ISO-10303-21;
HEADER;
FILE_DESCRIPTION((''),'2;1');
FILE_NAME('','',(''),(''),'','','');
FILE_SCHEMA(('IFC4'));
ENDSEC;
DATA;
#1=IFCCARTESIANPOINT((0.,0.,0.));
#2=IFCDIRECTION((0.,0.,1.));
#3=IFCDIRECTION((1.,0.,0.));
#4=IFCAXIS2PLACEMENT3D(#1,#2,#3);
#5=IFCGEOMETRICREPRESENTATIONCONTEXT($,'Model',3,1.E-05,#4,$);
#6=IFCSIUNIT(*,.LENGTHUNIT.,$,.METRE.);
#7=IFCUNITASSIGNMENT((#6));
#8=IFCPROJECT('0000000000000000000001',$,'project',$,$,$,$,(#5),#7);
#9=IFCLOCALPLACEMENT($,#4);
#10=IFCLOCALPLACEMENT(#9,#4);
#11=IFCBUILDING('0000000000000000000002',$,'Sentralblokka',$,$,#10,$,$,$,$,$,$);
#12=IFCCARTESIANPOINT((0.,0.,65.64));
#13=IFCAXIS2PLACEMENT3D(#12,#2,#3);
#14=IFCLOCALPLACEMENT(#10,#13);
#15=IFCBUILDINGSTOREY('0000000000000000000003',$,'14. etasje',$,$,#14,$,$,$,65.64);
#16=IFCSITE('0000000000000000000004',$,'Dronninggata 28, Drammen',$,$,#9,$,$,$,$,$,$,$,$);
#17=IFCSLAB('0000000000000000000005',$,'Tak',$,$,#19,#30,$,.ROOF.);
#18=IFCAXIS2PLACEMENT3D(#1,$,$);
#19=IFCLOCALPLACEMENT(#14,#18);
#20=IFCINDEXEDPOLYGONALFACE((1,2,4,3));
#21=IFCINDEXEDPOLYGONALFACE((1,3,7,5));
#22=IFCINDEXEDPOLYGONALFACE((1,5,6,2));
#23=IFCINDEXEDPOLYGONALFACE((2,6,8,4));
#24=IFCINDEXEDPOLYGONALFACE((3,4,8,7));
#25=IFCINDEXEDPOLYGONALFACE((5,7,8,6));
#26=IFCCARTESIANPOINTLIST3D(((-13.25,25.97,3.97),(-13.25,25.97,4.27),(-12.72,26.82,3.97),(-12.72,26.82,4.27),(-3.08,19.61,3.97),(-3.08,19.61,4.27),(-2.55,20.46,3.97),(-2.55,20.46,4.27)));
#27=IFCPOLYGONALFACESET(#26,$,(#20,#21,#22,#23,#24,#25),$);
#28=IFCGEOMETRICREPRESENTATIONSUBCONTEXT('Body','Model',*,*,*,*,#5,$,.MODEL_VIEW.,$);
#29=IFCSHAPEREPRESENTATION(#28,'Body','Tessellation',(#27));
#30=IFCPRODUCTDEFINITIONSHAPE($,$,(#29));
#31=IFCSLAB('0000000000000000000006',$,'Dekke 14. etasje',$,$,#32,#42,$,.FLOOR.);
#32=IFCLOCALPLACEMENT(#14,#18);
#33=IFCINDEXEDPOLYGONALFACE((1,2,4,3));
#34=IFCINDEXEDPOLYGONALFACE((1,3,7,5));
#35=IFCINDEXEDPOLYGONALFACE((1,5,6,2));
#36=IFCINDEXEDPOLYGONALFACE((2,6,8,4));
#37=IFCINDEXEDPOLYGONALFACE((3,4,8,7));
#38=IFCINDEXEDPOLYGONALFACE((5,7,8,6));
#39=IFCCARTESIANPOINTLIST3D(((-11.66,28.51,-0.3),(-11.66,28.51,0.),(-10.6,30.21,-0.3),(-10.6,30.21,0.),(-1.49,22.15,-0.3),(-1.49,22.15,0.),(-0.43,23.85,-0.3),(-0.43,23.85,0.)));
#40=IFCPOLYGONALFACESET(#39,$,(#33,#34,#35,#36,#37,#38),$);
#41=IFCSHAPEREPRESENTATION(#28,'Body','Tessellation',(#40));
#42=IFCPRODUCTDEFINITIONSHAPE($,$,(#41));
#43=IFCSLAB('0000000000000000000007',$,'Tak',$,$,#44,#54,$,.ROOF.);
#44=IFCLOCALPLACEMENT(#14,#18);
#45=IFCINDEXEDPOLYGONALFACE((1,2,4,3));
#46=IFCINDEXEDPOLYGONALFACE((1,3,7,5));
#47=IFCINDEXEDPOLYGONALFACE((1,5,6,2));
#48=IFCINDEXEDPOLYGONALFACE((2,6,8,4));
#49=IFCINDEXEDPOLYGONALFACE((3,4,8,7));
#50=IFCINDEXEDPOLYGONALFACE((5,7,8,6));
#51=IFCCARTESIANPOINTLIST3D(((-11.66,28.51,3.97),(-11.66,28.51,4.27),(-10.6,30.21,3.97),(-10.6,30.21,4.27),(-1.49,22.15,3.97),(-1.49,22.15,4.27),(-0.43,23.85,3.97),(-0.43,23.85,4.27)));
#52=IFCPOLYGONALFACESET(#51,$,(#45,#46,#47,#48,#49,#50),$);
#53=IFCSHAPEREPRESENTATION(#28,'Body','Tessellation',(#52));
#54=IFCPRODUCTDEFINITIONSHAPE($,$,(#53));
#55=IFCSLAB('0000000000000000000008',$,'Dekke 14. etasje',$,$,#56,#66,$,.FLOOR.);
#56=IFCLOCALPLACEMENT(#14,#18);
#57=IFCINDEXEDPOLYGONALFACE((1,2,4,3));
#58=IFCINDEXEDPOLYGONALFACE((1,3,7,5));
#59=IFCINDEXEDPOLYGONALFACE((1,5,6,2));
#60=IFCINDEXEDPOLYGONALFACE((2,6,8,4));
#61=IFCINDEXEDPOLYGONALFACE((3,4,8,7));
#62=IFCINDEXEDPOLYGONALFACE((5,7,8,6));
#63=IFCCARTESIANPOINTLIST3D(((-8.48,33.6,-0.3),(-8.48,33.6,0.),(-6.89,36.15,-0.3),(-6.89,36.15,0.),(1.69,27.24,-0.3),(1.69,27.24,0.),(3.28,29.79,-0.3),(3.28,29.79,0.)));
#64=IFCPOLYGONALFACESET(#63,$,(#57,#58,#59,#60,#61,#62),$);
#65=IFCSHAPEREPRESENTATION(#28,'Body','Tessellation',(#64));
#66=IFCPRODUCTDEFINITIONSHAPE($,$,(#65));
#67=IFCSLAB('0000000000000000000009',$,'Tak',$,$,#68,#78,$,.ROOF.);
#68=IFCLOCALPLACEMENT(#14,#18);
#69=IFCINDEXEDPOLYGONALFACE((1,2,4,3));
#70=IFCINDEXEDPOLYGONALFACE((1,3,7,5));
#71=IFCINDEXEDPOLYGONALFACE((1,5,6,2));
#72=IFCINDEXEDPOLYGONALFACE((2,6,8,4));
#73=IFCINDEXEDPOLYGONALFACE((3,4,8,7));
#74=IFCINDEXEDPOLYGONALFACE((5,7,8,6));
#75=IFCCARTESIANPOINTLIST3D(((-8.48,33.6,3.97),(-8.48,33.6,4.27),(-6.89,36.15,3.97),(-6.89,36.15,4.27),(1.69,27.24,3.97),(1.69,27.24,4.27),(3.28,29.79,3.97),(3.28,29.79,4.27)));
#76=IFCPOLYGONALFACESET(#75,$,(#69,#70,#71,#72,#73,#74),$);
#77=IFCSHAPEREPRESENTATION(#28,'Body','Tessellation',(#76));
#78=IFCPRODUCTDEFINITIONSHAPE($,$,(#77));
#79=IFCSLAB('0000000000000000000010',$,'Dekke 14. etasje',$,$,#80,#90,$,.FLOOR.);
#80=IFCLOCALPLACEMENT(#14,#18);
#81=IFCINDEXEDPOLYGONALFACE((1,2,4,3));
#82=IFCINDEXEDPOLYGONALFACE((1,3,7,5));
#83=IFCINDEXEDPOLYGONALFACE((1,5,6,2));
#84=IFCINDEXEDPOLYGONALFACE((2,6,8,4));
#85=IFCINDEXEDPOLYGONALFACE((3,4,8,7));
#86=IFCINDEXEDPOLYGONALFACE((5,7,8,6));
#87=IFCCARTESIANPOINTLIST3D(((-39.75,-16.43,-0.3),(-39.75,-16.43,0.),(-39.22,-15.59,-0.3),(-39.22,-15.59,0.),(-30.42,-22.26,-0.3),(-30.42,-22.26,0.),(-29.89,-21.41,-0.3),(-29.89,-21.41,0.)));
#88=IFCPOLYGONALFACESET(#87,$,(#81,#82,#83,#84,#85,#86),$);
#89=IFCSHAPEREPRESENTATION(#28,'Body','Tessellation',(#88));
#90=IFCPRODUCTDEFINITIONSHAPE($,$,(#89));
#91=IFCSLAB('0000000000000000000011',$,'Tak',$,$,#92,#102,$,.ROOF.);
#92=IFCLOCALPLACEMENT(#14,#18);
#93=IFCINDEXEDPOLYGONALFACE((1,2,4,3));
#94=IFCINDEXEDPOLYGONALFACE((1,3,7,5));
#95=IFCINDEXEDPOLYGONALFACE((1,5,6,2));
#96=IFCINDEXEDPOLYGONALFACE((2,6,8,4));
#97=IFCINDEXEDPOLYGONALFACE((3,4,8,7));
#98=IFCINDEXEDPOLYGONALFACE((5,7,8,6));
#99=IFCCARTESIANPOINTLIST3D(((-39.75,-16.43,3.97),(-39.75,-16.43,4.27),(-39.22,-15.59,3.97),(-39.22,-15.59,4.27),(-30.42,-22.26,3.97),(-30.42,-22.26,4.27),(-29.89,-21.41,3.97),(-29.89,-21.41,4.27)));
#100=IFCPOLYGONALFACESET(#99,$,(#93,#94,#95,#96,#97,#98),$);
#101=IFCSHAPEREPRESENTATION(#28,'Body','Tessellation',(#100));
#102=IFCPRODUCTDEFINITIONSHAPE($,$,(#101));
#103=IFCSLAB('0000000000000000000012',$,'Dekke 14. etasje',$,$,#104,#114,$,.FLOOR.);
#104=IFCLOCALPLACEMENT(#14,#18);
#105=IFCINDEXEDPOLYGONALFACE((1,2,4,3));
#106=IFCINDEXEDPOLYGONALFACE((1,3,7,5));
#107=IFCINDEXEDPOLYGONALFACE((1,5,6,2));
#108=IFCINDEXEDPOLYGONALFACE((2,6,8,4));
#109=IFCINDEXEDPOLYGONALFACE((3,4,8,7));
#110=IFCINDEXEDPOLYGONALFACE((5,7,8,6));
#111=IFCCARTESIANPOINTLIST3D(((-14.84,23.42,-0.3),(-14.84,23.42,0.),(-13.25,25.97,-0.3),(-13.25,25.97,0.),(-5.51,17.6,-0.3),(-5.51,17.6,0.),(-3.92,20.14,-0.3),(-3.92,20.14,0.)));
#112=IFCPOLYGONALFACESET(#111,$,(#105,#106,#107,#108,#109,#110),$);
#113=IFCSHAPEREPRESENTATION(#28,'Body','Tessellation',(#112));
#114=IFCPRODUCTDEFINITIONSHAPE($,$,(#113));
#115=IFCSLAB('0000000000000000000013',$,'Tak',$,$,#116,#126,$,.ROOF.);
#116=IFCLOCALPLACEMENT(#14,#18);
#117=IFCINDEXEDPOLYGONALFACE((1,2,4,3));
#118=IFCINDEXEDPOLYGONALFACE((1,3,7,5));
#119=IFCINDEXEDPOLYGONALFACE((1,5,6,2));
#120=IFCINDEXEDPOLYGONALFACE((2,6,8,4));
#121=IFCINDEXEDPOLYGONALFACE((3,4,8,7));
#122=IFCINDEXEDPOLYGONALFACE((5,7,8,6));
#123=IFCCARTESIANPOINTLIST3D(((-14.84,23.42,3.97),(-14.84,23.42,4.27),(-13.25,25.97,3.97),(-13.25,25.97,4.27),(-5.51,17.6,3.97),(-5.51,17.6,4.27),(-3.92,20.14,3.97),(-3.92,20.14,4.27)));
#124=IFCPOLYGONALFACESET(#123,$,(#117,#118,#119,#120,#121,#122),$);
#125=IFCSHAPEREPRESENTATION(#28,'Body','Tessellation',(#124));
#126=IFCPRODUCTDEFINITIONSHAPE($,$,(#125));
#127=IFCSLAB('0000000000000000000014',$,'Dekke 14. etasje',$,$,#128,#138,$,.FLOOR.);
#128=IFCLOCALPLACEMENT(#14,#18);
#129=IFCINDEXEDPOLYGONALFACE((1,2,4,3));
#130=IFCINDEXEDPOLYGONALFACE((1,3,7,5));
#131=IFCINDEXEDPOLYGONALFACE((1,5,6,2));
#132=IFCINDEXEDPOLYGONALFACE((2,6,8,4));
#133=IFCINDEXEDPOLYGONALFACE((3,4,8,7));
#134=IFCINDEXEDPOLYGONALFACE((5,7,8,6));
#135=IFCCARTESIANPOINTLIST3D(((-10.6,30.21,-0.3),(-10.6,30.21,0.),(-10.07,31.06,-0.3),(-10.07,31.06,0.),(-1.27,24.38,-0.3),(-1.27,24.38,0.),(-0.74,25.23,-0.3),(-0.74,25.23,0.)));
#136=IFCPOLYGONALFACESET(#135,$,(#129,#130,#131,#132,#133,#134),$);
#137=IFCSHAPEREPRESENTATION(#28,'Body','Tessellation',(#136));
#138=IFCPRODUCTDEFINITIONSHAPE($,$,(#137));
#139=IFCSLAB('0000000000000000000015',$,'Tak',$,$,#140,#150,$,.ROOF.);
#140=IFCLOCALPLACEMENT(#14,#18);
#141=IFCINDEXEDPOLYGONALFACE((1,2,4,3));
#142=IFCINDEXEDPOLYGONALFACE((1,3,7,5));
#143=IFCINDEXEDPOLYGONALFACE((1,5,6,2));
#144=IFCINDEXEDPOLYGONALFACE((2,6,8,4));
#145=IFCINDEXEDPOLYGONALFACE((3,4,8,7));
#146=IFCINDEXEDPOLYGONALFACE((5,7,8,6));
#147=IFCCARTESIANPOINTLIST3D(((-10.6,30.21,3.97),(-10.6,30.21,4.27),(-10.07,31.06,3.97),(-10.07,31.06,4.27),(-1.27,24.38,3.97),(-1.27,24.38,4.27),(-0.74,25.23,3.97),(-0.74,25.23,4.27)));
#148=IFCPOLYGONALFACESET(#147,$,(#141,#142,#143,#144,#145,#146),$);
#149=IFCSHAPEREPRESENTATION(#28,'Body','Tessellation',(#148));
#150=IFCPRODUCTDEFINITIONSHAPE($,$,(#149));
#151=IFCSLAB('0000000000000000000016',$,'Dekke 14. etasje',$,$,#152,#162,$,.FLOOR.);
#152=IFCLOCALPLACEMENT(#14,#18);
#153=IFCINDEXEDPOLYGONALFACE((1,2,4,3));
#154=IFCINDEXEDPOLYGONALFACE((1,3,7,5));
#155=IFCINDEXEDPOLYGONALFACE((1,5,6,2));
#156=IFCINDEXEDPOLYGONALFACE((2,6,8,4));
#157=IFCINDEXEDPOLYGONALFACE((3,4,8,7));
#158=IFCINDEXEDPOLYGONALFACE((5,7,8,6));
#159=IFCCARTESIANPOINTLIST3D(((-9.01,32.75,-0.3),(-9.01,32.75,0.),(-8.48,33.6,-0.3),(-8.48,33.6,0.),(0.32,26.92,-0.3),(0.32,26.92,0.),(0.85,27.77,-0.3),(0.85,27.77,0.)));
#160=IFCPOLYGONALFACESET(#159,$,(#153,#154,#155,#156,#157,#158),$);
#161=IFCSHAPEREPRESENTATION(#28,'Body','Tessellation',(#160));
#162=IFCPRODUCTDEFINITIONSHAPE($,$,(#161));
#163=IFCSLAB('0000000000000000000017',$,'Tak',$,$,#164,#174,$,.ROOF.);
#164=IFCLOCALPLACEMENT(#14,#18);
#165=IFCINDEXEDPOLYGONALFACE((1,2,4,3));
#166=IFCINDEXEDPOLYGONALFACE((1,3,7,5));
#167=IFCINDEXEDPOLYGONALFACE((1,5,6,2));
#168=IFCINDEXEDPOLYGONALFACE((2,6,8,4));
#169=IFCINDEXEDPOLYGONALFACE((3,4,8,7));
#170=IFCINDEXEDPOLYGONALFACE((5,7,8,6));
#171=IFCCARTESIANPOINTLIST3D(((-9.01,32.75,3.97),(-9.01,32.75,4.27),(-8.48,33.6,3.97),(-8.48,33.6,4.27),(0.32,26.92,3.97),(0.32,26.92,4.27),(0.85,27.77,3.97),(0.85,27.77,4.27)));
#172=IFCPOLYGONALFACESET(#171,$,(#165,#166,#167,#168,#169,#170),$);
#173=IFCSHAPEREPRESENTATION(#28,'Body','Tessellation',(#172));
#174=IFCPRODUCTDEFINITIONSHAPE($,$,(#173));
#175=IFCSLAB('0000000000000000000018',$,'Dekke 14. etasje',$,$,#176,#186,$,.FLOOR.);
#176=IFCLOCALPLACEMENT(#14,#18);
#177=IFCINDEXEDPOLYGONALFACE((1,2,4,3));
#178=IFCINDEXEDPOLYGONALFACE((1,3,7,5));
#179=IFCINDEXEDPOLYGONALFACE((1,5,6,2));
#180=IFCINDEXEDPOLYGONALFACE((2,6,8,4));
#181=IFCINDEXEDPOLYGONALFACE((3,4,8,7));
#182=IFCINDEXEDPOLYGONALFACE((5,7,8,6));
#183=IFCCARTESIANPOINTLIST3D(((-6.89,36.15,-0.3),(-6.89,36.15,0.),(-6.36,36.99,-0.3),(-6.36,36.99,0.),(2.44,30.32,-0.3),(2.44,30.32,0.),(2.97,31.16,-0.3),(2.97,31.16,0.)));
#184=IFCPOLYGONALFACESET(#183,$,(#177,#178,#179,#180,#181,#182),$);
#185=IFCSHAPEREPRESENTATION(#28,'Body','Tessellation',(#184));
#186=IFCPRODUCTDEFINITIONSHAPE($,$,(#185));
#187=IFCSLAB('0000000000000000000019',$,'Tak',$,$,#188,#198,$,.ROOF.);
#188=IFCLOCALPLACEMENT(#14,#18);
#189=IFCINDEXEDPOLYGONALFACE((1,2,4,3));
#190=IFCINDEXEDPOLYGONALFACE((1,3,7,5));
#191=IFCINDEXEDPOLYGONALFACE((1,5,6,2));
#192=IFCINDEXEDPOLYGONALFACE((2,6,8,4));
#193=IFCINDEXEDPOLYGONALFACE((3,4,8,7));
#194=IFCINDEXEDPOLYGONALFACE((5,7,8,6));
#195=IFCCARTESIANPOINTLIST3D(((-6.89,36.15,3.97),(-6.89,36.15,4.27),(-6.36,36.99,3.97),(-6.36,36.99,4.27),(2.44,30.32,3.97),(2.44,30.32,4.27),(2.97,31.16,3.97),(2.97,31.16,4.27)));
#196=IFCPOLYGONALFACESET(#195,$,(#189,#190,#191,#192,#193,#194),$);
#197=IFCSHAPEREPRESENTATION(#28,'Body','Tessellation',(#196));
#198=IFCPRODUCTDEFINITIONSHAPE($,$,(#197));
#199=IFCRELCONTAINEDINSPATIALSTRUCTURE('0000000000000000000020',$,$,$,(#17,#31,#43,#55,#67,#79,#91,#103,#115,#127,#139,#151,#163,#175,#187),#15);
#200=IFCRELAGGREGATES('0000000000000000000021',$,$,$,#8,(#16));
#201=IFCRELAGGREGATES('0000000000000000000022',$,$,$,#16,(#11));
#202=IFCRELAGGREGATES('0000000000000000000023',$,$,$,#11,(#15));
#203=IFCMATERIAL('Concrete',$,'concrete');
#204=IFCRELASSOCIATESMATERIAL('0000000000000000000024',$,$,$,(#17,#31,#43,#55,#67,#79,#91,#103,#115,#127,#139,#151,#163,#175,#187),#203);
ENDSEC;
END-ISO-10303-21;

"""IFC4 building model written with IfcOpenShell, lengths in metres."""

from ifc_helpers import new_model, si_unit, frame, origin_with_axes, place, context, subcontext, project, spatial, polyline, outline, extrude, material, element, save


model = new_model("IFC4")

# Units and contexts
model_context = context("Model", 3, precision=1e-05, world=origin_with_axes())
body_context = subcontext(model_context, "Body", "Model", "MODEL_VIEW")
ifc_project = project(units=[si_unit("LENGTHUNIT", "METRE")], contexts=[model_context])

# Site, building, storey
site_placement = place(None, origin_with_axes())
site = spatial("IfcSite", under=ifc_project, at=site_placement, Name="Dronninggata 28, Drammen")
building_placement = place(site_placement, origin_with_axes())
building = spatial("IfcBuilding", under=site, at=building_placement, Name="Sentralblokka")
storey_placement = place(building_placement, frame((0.0, 0.0, 65.64), z_axis=(0.0, 0.0, 1.0), x_axis=(1.0, 0.0, 0.0)))
storey = spatial("IfcBuildingStorey", under=building, at=storey_placement, Name="14. etasje", Elevation=65.64)

# Slabs
ifc_material = material(Name="Concrete", Category="concrete")
slab_1_placement = place(storey_placement, frame((0.0, 0.0, -65.64), z_axis=(0.0, 0.0, 1.0), x_axis=(1.0, 0.0, 0.0)))
element("IfcSlab", 1, at=slab_1_placement, inside=storey, material=ifc_material, Name="Tak", PredefinedType="ROOF", context=body_context, shape_type="SweptSolid", body=[
    extrude(outline(polyline([(-3.08, 19.61), (-2.55, 20.46), (-12.72, 26.82), (-13.25, 25.97), (-3.08, 19.61)])), frame((0.0, 0.0, 69.61)), (0.0, 0.0, 1.0), 0.3),
])
slab_2_placement = place(storey_placement, frame((0.0, 0.0, -65.64), z_axis=(0.0, 0.0, 1.0), x_axis=(1.0, 0.0, 0.0)))
element("IfcSlab", 2, at=slab_2_placement, inside=storey, material=ifc_material, Name="Dekke 14. etasje", PredefinedType="FLOOR", context=body_context, shape_type="SweptSolid", body=[
    extrude(outline(polyline([(-1.49, 22.15), (-0.43, 23.85), (-10.6, 30.21), (-11.66, 28.51), (-1.49, 22.15)])), frame((0.0, 0.0, 65.34)), (0.0, 0.0, 1.0), 0.3),
])
slab_3_placement = place(storey_placement, frame((0.0, 0.0, -65.64), z_axis=(0.0, 0.0, 1.0), x_axis=(1.0, 0.0, 0.0)))
element("IfcSlab", 3, at=slab_3_placement, inside=storey, material=ifc_material, Name="Tak", PredefinedType="ROOF", context=body_context, shape_type="SweptSolid", body=[
    extrude(outline(polyline([(-1.49, 22.15), (-0.43, 23.85), (-10.6, 30.21), (-11.66, 28.51), (-1.49, 22.15)])), frame((0.0, 0.0, 69.61)), (0.0, 0.0, 1.0), 0.3),
])
slab_4_placement = place(storey_placement, frame((0.0, 0.0, -65.64), z_axis=(0.0, 0.0, 1.0), x_axis=(1.0, 0.0, 0.0)))
element("IfcSlab", 4, at=slab_4_placement, inside=storey, material=ifc_material, Name="Dekke 14. etasje", PredefinedType="FLOOR", context=body_context, shape_type="SweptSolid", body=[
    extrude(outline(polyline([(1.69, 27.24), (3.28, 29.79), (-6.89, 36.15), (-8.48, 33.6), (1.69, 27.24)])), frame((0.0, 0.0, 65.34)), (0.0, 0.0, 1.0), 0.3),
])
slab_5_placement = place(storey_placement, frame((0.0, 0.0, -65.64), z_axis=(0.0, 0.0, 1.0), x_axis=(1.0, 0.0, 0.0)))
element("IfcSlab", 5, at=slab_5_placement, inside=storey, material=ifc_material, Name="Tak", PredefinedType="ROOF", context=body_context, shape_type="SweptSolid", body=[
    extrude(outline(polyline([(1.69, 27.24), (3.28, 29.79), (-6.89, 36.15), (-8.48, 33.6), (1.69, 27.24)])), frame((0.0, 0.0, 69.61)), (0.0, 0.0, 1.0), 0.3),
])
slab_6_placement = place(storey_placement, frame((0.0, 0.0, -65.64), z_axis=(0.0, 0.0, 1.0), x_axis=(1.0, 0.0, 0.0)))
element("IfcSlab", 6, at=slab_6_placement, inside=storey, material=ifc_material, Name="Dekke 14. etasje", PredefinedType="FLOOR", context=body_context, shape_type="SweptSolid", body=[
    extrude(outline(polyline([(-30.42, -22.26), (-29.89, -21.41), (-39.22, -15.59), (-39.75, -16.43), (-30.42, -22.26)])), frame((0.0, 0.0, 65.34)), (0.0, 0.0, 1.0), 0.3),
])
slab_7_placement = place(storey_placement, frame((0.0, 0.0, -65.64), z_axis=(0.0, 0.0, 1.0), x_axis=(1.0, 0.0, 0.0)))
element("IfcSlab", 7, at=slab_7_placement, inside=storey, material=ifc_material, Name="Tak", PredefinedType="ROOF", context=body_context, shape_type="SweptSolid", body=[
    extrude(outline(polyline([(-30.42, -22.26), (-29.89, -21.41), (-39.22, -15.59), (-39.75, -16.43), (-30.42, -22.26)])), frame((0.0, 0.0, 69.61)), (0.0, 0.0, 1.0), 0.3),
])
slab_8_placement = place(storey_placement, frame((0.0, 0.0, -65.64), z_axis=(0.0, 0.0, 1.0), x_axis=(1.0, 0.0, 0.0)))
element("IfcSlab", 8, at=slab_8_placement, inside=storey, material=ifc_material, Name="Dekke 14. etasje", PredefinedType="FLOOR", context=body_context, shape_type="SweptSolid", body=[
    extrude(outline(polyline([(-5.51, 17.6), (-3.92, 20.14), (-13.25, 25.97), (-14.84, 23.42), (-5.51, 17.6)])), frame((0.0, 0.0, 65.34)), (0.0, 0.0, 1.0), 0.3),
])
slab_9_placement = place(storey_placement, frame((0.0, 0.0, -65.64), z_axis=(0.0, 0.0, 1.0), x_axis=(1.0, 0.0, 0.0)))
element("IfcSlab", 9, at=slab_9_placement, inside=storey, material=ifc_material, Name="Tak", PredefinedType="ROOF", context=body_context, shape_type="SweptSolid", body=[
    extrude(outline(polyline([(-5.51, 17.6), (-3.92, 20.14), (-13.25, 25.97), (-14.84, 23.42), (-5.51, 17.6)])), frame((0.0, 0.0, 69.61)), (0.0, 0.0, 1.0), 0.3),
])
slab_10_placement = place(storey_placement, frame((0.0, 0.0, -65.64), z_axis=(0.0, 0.0, 1.0), x_axis=(1.0, 0.0, 0.0)))
element("IfcSlab", 10, at=slab_10_placement, inside=storey, material=ifc_material, Name="Dekke 14. etasje", PredefinedType="FLOOR", context=body_context, shape_type="SweptSolid", body=[
    extrude(outline(polyline([(-1.27, 24.38), (-0.74, 25.23), (-10.07, 31.06), (-10.6, 30.21), (-1.27, 24.38)])), frame((0.0, 0.0, 65.34)), (0.0, 0.0, 1.0), 0.3),
])
slab_11_placement = place(storey_placement, frame((0.0, 0.0, -65.64), z_axis=(0.0, 0.0, 1.0), x_axis=(1.0, 0.0, 0.0)))
element("IfcSlab", 11, at=slab_11_placement, inside=storey, material=ifc_material, Name="Tak", PredefinedType="ROOF", context=body_context, shape_type="SweptSolid", body=[
    extrude(outline(polyline([(-1.27, 24.38), (-0.74, 25.23), (-10.07, 31.06), (-10.6, 30.21), (-1.27, 24.38)])), frame((0.0, 0.0, 69.61)), (0.0, 0.0, 1.0), 0.3),
])
slab_12_placement = place(storey_placement, frame((0.0, 0.0, -65.64), z_axis=(0.0, 0.0, 1.0), x_axis=(1.0, 0.0, 0.0)))
element("IfcSlab", 12, at=slab_12_placement, inside=storey, material=ifc_material, Name="Dekke 14. etasje", PredefinedType="FLOOR", context=body_context, shape_type="SweptSolid", body=[
    extrude(outline(polyline([(0.32, 26.92), (0.85, 27.77), (-8.48, 33.6), (-9.01, 32.75), (0.32, 26.92)])), frame((0.0, 0.0, 65.34)), (0.0, 0.0, 1.0), 0.3),
])
slab_13_placement = place(storey_placement, frame((0.0, 0.0, -65.64), z_axis=(0.0, 0.0, 1.0), x_axis=(1.0, 0.0, 0.0)))
element("IfcSlab", 13, at=slab_13_placement, inside=storey, material=ifc_material, Name="Tak", PredefinedType="ROOF", context=body_context, shape_type="SweptSolid", body=[
    extrude(outline(polyline([(0.32, 26.92), (0.85, 27.77), (-8.48, 33.6), (-9.01, 32.75), (0.32, 26.92)])), frame((0.0, 0.0, 69.61)), (0.0, 0.0, 1.0), 0.3),
])
slab_14_placement = place(storey_placement, frame((0.0, 0.0, -65.64), z_axis=(0.0, 0.0, 1.0), x_axis=(1.0, 0.0, 0.0)))
element("IfcSlab", 14, at=slab_14_placement, inside=storey, material=ifc_material, Name="Dekke 14. etasje", PredefinedType="FLOOR", context=body_context, shape_type="SweptSolid", body=[
    extrude(outline(polyline([(2.44, 30.32), (2.97, 31.16), (-6.36, 36.99), (-6.89, 36.15), (2.44, 30.32)])), frame((0.0, 0.0, 65.34)), (0.0, 0.0, 1.0), 0.3),
])
slab_15_placement = place(storey_placement, frame((0.0, 0.0, -65.64), z_axis=(0.0, 0.0, 1.0), x_axis=(1.0, 0.0, 0.0)))
element("IfcSlab", 15, at=slab_15_placement, inside=storey, material=ifc_material, Name="Tak", PredefinedType="ROOF", context=body_context, shape_type="SweptSolid", body=[
    extrude(outline(polyline([(2.44, 30.32), (2.97, 31.16), (-6.36, 36.99), (-6.89, 36.15), (2.44, 30.32)])), frame((0.0, 0.0, 69.61)), (0.0, 0.0, 1.0), 0.3),
])

save(model, "model.ifc")
